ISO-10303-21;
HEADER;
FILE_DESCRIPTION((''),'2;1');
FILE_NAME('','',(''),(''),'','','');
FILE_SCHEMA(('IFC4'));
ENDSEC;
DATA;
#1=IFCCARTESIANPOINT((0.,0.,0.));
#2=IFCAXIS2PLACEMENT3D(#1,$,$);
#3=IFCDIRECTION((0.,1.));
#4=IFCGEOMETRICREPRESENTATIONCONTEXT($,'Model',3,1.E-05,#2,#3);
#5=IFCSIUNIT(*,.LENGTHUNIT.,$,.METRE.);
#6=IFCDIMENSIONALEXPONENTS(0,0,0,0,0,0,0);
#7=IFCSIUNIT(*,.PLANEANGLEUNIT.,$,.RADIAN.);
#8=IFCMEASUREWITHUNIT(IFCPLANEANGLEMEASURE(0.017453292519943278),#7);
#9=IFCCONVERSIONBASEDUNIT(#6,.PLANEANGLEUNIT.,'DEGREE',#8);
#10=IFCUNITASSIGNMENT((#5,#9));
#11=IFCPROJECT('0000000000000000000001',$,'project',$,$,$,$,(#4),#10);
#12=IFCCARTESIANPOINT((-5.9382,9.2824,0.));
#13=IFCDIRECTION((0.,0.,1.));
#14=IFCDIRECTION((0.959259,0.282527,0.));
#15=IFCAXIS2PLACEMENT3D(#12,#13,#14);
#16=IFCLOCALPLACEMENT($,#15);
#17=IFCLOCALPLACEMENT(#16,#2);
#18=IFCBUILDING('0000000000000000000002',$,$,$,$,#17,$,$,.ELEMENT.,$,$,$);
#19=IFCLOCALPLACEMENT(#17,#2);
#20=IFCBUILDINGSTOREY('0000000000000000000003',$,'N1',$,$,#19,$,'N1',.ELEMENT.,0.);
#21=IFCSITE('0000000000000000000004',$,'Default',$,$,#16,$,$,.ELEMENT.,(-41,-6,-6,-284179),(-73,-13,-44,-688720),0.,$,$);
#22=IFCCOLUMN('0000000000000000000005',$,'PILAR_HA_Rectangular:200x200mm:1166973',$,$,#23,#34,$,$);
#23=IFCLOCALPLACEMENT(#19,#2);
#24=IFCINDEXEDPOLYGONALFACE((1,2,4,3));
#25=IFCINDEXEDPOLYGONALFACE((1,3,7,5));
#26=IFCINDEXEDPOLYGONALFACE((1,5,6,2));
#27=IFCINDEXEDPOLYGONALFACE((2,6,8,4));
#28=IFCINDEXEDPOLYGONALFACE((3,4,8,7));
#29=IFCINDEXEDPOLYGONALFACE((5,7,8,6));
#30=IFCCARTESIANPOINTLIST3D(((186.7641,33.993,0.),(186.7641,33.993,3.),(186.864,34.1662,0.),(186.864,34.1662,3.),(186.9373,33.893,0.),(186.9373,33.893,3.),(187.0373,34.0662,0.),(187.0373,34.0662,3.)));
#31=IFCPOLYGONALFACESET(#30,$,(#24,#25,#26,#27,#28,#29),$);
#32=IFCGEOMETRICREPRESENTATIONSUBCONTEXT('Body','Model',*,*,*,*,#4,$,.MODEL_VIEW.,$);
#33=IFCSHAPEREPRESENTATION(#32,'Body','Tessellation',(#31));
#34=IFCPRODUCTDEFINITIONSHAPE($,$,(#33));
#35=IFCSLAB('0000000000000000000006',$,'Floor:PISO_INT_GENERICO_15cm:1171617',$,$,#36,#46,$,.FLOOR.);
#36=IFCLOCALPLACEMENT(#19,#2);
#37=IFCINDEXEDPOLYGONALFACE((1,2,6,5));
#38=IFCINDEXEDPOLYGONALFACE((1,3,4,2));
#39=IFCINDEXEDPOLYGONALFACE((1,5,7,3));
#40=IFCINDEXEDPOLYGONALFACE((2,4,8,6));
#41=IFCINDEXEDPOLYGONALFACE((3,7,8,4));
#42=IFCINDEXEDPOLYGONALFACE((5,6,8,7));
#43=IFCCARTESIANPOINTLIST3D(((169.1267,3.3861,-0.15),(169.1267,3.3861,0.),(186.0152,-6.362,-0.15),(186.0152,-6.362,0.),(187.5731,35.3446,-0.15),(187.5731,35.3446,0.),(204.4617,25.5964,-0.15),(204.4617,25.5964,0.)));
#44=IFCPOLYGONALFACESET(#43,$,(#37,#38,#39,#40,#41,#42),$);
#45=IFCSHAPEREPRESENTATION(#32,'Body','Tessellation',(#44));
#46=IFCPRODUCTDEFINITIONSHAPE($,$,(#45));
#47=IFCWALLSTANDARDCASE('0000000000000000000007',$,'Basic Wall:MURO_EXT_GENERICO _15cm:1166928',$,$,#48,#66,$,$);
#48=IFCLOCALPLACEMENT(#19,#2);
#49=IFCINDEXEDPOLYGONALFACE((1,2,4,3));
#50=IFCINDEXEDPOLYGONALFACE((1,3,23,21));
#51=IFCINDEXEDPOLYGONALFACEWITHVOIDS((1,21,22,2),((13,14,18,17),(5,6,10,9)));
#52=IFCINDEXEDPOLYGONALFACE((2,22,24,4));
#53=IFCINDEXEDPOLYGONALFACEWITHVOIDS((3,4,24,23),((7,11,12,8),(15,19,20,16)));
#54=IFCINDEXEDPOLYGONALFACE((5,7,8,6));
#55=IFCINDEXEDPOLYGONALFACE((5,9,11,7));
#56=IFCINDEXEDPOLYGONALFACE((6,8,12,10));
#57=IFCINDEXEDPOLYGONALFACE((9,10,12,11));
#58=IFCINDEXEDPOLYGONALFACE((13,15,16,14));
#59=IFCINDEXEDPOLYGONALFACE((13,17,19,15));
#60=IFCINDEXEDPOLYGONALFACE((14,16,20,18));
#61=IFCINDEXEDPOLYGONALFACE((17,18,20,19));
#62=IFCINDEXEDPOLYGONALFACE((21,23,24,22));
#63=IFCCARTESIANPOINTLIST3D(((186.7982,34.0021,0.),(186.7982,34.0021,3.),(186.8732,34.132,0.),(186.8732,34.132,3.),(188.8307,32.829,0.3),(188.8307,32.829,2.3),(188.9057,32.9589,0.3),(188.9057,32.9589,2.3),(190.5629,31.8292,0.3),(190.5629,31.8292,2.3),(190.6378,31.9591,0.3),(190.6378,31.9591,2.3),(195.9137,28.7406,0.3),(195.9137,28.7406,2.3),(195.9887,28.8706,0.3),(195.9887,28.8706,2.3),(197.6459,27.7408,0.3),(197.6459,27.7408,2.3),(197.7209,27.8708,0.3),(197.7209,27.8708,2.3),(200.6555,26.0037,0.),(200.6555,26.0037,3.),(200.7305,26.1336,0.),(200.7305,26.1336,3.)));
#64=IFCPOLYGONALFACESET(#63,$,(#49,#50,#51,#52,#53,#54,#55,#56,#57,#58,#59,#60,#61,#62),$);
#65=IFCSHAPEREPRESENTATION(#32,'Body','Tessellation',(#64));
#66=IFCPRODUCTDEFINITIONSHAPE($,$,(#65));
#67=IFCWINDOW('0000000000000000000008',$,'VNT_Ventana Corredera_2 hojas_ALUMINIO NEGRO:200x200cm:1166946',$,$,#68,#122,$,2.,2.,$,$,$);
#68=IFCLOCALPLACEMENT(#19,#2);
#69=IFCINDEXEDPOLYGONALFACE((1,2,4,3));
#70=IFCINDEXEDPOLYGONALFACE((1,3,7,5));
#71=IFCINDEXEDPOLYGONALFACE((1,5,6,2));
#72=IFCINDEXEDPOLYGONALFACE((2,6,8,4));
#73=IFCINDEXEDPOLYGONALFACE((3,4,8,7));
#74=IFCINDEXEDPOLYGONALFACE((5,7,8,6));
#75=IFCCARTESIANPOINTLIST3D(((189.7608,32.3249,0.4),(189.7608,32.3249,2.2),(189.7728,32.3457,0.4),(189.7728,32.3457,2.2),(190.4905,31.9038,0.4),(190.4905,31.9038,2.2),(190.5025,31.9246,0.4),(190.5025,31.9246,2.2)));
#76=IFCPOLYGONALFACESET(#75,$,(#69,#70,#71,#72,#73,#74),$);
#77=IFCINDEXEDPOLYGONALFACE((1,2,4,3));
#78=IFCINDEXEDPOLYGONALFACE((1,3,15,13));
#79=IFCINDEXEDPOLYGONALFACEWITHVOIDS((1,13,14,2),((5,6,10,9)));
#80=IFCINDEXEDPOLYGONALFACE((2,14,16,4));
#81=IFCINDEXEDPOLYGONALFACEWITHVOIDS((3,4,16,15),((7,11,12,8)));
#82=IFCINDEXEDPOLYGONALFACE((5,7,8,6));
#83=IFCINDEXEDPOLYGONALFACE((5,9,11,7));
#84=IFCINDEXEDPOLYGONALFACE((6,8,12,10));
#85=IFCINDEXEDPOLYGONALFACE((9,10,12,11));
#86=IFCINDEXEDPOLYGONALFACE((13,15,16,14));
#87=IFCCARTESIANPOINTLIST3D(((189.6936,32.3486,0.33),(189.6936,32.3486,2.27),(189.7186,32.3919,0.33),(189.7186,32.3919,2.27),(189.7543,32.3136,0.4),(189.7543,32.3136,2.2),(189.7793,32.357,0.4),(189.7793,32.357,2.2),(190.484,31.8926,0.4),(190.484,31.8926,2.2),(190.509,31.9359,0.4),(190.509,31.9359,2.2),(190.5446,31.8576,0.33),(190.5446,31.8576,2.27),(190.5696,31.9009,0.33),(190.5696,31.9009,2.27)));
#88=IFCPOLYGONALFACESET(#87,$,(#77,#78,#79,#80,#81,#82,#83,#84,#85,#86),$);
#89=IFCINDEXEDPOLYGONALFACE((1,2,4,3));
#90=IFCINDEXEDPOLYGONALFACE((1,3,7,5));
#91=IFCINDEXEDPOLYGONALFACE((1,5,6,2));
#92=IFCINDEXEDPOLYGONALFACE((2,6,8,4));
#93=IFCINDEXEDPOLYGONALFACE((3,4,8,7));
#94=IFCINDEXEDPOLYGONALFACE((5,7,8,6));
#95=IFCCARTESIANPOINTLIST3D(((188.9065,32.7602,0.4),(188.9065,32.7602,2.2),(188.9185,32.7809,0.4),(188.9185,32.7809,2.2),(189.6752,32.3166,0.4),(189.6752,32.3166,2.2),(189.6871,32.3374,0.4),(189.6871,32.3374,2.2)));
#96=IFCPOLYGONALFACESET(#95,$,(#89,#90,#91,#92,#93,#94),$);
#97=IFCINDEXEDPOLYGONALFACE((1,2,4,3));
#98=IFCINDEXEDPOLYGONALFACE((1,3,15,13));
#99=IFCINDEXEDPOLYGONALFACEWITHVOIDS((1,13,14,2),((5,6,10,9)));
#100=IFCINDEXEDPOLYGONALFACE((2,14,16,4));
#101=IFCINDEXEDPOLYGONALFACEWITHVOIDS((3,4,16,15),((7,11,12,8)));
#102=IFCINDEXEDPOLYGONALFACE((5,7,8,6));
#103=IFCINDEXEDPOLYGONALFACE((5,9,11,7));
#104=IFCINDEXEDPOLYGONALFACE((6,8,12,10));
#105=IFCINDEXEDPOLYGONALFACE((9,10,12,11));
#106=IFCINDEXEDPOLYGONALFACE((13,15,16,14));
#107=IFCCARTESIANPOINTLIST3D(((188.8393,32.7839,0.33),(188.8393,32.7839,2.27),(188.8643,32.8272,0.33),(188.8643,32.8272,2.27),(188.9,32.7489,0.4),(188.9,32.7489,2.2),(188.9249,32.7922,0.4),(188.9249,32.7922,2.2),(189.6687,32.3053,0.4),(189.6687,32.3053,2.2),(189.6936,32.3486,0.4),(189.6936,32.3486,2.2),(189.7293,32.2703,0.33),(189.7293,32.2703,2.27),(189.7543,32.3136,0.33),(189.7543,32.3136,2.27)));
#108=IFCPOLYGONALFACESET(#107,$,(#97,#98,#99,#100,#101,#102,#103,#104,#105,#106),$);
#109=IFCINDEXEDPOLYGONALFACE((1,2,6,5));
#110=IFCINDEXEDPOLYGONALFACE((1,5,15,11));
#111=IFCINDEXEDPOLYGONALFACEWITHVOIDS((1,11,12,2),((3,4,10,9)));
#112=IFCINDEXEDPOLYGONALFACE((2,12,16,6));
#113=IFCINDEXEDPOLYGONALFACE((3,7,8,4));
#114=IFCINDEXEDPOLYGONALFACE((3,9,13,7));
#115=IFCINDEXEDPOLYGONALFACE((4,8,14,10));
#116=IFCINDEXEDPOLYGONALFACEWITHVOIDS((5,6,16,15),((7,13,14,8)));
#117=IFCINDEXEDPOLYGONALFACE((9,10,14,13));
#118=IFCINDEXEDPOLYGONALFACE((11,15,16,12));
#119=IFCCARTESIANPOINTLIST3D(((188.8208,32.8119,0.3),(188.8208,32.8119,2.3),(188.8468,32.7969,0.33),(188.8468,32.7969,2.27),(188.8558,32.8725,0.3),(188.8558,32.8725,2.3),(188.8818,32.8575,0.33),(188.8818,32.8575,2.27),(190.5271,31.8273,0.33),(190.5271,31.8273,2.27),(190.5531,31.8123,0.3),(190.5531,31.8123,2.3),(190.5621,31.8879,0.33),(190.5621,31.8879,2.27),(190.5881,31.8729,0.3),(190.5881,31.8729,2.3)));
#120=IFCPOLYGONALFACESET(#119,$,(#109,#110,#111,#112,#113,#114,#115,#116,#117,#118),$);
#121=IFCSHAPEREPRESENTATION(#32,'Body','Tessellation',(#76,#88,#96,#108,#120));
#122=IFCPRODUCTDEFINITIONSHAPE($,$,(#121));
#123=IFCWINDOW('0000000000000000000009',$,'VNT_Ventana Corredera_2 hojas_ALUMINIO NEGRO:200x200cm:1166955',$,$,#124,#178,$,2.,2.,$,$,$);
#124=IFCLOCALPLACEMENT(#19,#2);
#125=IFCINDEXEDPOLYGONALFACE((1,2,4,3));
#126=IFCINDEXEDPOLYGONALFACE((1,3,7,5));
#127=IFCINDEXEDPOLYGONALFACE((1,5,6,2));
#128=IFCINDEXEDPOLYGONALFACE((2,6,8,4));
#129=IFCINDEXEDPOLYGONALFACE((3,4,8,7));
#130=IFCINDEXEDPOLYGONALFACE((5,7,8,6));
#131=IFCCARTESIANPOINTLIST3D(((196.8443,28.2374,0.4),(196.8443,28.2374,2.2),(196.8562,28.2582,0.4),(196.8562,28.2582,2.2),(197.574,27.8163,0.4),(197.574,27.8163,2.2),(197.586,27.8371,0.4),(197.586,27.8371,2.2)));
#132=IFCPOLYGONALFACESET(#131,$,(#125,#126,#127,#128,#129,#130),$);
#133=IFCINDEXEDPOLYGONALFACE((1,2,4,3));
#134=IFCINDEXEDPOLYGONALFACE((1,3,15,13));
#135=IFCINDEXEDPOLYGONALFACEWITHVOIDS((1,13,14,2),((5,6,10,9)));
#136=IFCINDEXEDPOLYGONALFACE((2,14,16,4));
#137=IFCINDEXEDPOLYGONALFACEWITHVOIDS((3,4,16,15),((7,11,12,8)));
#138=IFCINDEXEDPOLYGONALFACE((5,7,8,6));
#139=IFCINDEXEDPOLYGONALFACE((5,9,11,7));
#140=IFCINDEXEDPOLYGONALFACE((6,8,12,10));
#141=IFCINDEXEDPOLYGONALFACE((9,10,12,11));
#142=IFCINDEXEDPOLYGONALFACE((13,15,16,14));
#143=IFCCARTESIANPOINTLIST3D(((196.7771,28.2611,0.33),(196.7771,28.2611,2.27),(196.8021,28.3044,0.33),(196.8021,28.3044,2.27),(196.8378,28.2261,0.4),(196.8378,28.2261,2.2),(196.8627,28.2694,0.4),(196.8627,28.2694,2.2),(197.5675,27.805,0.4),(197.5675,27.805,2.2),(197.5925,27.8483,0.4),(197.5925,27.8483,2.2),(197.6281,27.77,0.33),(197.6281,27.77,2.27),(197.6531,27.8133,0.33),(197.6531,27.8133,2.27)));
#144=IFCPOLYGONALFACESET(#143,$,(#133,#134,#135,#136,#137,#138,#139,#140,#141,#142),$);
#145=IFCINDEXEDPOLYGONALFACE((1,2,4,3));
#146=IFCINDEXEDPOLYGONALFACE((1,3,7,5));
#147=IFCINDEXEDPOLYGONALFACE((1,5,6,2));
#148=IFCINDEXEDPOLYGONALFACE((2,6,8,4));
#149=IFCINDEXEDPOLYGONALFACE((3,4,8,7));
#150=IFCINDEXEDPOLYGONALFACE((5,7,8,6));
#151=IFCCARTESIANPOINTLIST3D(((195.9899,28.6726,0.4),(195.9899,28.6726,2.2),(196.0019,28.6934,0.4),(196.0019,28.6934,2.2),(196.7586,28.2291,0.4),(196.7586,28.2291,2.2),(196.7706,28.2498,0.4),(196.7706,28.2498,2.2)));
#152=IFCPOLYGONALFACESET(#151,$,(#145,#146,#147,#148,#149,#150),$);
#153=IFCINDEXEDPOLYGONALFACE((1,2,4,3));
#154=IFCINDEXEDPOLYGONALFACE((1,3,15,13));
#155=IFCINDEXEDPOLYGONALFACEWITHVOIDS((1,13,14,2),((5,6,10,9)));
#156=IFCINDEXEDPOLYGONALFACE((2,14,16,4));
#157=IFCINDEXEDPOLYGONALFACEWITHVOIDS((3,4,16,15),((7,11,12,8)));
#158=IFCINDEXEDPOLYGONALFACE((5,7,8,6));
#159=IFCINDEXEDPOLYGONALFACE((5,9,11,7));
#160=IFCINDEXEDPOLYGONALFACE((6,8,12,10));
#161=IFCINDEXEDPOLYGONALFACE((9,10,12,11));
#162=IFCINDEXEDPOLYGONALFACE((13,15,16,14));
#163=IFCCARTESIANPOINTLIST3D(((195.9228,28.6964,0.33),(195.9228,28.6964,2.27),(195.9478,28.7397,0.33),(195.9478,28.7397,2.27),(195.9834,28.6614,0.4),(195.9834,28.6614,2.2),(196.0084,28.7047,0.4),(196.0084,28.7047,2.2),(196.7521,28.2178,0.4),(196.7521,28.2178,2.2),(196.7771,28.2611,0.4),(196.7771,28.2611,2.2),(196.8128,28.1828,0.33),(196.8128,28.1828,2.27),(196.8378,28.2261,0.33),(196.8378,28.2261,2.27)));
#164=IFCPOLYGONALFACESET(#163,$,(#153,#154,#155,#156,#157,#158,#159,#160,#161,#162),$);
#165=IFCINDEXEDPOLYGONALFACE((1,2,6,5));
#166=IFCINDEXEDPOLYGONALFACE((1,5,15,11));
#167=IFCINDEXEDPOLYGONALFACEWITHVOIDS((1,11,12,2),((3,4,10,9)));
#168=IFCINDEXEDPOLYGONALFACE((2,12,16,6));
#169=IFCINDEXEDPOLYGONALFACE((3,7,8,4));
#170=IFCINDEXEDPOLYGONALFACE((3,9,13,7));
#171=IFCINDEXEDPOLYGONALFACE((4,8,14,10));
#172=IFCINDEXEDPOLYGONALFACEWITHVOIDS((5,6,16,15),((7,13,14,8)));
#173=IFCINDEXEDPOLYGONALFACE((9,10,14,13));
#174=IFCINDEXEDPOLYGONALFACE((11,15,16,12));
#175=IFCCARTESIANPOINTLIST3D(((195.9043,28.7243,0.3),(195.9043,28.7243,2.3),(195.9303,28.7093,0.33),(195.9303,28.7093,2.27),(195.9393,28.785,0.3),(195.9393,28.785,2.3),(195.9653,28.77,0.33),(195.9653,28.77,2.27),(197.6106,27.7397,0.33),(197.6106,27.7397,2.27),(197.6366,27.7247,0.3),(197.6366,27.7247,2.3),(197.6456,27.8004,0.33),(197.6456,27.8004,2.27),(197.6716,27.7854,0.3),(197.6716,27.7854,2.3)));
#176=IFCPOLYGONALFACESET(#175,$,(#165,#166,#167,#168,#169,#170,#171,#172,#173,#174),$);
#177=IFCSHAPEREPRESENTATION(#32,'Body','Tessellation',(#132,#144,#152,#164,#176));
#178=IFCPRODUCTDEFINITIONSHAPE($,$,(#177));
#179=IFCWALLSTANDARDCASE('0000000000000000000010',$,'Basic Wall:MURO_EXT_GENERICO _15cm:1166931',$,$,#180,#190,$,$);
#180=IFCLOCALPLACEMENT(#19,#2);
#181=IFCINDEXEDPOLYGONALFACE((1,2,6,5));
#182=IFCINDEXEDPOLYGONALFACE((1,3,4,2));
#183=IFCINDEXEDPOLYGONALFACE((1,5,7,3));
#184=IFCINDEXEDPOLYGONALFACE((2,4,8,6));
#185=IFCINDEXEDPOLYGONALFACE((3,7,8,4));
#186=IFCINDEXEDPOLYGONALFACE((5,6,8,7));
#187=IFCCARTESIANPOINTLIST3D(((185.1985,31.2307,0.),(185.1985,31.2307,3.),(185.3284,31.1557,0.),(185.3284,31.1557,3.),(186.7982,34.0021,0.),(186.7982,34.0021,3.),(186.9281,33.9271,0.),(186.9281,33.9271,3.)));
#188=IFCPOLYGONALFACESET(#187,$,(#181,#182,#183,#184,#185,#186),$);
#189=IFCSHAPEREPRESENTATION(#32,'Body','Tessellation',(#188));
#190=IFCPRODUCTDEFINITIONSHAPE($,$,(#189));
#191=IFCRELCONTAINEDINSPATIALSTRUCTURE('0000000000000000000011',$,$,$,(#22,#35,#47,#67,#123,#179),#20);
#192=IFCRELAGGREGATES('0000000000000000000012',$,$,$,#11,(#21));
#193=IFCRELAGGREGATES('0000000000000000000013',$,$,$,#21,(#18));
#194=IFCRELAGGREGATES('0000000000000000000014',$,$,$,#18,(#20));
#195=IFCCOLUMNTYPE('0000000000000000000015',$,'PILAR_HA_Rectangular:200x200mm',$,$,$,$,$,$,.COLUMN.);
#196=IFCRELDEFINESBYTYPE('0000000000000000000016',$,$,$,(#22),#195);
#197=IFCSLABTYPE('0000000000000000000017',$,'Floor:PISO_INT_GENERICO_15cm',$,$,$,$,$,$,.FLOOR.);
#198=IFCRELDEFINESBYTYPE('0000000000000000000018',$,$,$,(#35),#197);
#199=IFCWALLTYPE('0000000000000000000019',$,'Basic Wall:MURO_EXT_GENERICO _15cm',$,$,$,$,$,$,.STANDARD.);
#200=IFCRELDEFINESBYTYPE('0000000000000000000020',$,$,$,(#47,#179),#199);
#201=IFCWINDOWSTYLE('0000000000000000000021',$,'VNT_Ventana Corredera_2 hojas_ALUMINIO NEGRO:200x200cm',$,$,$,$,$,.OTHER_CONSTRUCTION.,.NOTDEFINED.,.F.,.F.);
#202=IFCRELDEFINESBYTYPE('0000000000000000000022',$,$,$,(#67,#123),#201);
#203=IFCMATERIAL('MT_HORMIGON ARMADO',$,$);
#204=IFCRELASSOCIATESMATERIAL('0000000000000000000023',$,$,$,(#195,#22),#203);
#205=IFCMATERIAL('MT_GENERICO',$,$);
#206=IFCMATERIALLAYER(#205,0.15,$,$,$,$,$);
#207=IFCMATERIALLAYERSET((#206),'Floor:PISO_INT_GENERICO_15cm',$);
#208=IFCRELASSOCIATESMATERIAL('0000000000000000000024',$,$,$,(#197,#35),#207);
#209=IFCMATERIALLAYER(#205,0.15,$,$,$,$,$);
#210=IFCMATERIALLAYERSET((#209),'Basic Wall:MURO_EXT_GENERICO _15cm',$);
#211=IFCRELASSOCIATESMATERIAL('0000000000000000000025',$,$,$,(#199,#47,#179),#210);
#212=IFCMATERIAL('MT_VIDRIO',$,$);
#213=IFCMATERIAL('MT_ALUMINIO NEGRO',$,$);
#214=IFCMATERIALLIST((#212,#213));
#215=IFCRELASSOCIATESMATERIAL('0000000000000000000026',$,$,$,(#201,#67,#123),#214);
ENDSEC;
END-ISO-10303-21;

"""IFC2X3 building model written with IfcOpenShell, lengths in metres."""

from ifc_helpers import new_model, entity, si_unit, converted_unit, direction, frame, frame_2d, origin, origin_2d_with_axis, place, context, subcontext, project, spatial, polyline, rectangle, outline, extrude, source, transform, mapped, material, material_list, layer, layer_set, layer_usage, type_object, type_shapes, element, fill, save


model = new_model("IFC2X3")

# Units and contexts
model_context = context("Model", 3, precision=1e-05, world=origin(), true_north=direction((0.0, 1.0)))
body_context = subcontext(model_context, "Body", "Model", "MODEL_VIEW")
ifc_project = project(units=[si_unit("LENGTHUNIT", "METRE"), converted_unit("PLANEANGLEUNIT", "DEGREE", entity("IfcPlaneAngleMeasure", 0.017453292519943278), si_unit("PLANEANGLEUNIT", "RADIAN"), dimensions=[0, 0, 0, 0, 0, 0, 0])], contexts=[model_context])

# Site, building, storey
site_placement = place(None, frame((-5.9382, 9.2824, 0.0), z_axis=(0.0, 0.0, 1.0), x_axis=(0.959259, 0.282527, 0.0)))
site = spatial("IfcSite", under=ifc_project, at=site_placement, Name="Default", CompositionType="ELEMENT", RefLatitude=(-41, -6, -6, -284179), RefLongitude=(-73, -13, -44, -688720), RefElevation=0.0)
building_placement = place(site_placement, origin())
building = spatial("IfcBuilding", under=site, at=building_placement, CompositionType="ELEMENT")
storey_placement = place(building_placement, origin())
storey = spatial("IfcBuildingStorey", under=building, at=storey_placement, Name="N1", LongName="N1", CompositionType="ELEMENT", Elevation=0.0)

# Column
ifc_material_1 = material(Name="MT_HORMIGON ARMADO")
column_type = type_object("IfcColumnType", Name="PILAR_HA_Rectangular:200x200mm", PredefinedType="COLUMN", material=ifc_material_1)
shared_shape_1 = source(origin(), body_context, "Body", "SweptSolid", [
    extrude(rectangle(XDim=0.2, YDim=0.2, at=origin_2d_with_axis()), frame((0.0, 0.0, 0.0), z_axis=(0.0, 0.0, 1.0), x_axis=(-1.0, 0.0, 0.0)), (0.0, 0.0, 1.0), 3.0),
])
type_shapes(column_type, [shared_shape_1])
column_placement = place(storey_placement, frame((186.9007, 34.0296, 0.0), z_axis=(0.0, 0.0, 1.0), x_axis=(0.866082, -0.499903, 0.0)))
element("IfcColumn", 1, at=column_placement, inside=storey, type_object=column_type, material=ifc_material_1, Name="PILAR_HA_Rectangular:200x200mm:1166973", context=body_context, shape_type="MappedRepresentation", body=[
    mapped(shared_shape_1, transform((0.0, 0.0, 0.0), scale=1.0)),
])

# Slab
ifc_material_2 = material(Name="MT_GENERICO")
ifc_layer_1 = layer(ifc_material_2, 0.15)
ifc_layer_set_1 = layer_set([ifc_layer_1], Name="Floor:PISO_INT_GENERICO_15cm")
ifc_layer_usage_1 = layer_usage(ifc_layer_set_1, "AXIS3", "POSITIVE", 0.0)
slab_type = type_object("IfcSlabType", Name="Floor:PISO_INT_GENERICO_15cm", PredefinedType="FLOOR", material=ifc_layer_set_1)
slab_placement = place(storey_placement, origin())
element("IfcSlab", 2, at=slab_placement, inside=storey, type_object=slab_type, material=ifc_layer_usage_1, Name="Floor:PISO_INT_GENERICO_15cm:1171617", PredefinedType="FLOOR", context=body_context, shape_type="SweptSolid", body=[
    extrude(rectangle(XDim=36.9, YDim=19.5, at=frame_2d((0.0, 0.0), x_axis=(1.0, 0.0))), frame((186.7942, 14.4913, 0.0), z_axis=(0.0, 0.0, -1.0), x_axis=(-0.499903, -0.866082, 0.0)), (0.0, 0.0, 1.0), 0.15),
])

# Wall, openings, windows
ifc_layer_2 = layer(ifc_material_2, 0.15)
ifc_layer_set_2 = layer_set([ifc_layer_2], Name="Basic Wall:MURO_EXT_GENERICO _15cm")
ifc_layer_usage_2 = layer_usage(ifc_layer_set_2, "AXIS2", "NEGATIVE", 0.075)
wall_type_1 = type_object("IfcWallType", Name="Basic Wall:MURO_EXT_GENERICO _15cm", PredefinedType="STANDARD", material=ifc_layer_set_2)
wall_1_placement = place(storey_placement, frame((186.8357, 34.0671, 0.0), z_axis=(0.0, 0.0, 1.0), x_axis=(0.866082, -0.499903, 0.0)))
wall_1 = element("IfcWallStandardCase", 3, at=wall_1_placement, inside=storey, type_object=wall_type_1, material=ifc_layer_usage_2, Name="Basic Wall:MURO_EXT_GENERICO _15cm:1166928", context=body_context, shape_type="SweptSolid", body=[
    extrude(rectangle(XDim=16.0, YDim=0.15, at=frame_2d((8.0, 0.0), x_axis=(-1.0, 0.0))), origin(), (0.0, 0.0, 1.0), 3.0),
])
opening_1_placement = place(wall_1_placement, frame((4.3468, 0.075, 0.3)))
opening_1 = element("IfcOpeningElement", 4, at=opening_1_placement, cuts=wall_1, ObjectType="Opening", context=body_context, shape_type="SweptSolid", body=[
    extrude(rectangle(XDim=2.0, YDim=2.0, at=frame_2d((1.0, 1.0), x_axis=(1.0, 0.0))), frame((0.0, 0.0, 0.0), z_axis=(0.0, -1.0, 0.0), x_axis=(0.0, 0.0, 1.0)), (0.0, 0.0, 1.0), 0.15),
])
opening_2_placement = place(wall_1_placement, frame((12.525, 0.075, 0.3)))
opening_2 = element("IfcOpeningElement", 5, at=opening_2_placement, cuts=wall_1, ObjectType="Opening", context=body_context, shape_type="SweptSolid", body=[
    extrude(rectangle(XDim=2.0, YDim=2.0, at=frame_2d((1.0, 1.0), x_axis=(1.0, 0.0))), frame((0.0, 0.0, 0.0), z_axis=(0.0, -1.0, 0.0), x_axis=(0.0, 0.0, 1.0)), (0.0, 0.0, 1.0), 0.15),
])
ifc_material_3 = material(Name="MT_VIDRIO")
ifc_material_4 = material(Name="MT_ALUMINIO NEGRO")
ifc_material_list_1 = material_list([ifc_material_3, ifc_material_4])
window_style = type_object("IfcWindowStyle", Name="VNT_Ventana Corredera_2 hojas_ALUMINIO NEGRO:200x200cm", ConstructionType="OTHER_CONSTRUCTION", OperationType="NOTDEFINED", ParameterTakesPrecedence=False, Sizeable=False, material=ifc_material_list_1)
shared_shape_2 = source(origin(), body_context, "Body", "SweptSolid", [
    extrude(rectangle(XDim=0.024, YDim=0.8425, at=frame_2d((0.0, 0.0), x_axis=(1.0, 0.0))), frame((0.5213, 0.11, 0.1), z_axis=(0.0, 0.0, 1.0), x_axis=(0.0, -1.0, 0.0)), (0.0, 0.0, 1.0), 1.8),
    extrude(outline(polyline([(-0.4912, -0.97), (0.4913, -0.97), (0.4912, 0.97), (-0.4912, 0.97), (-0.4912, -0.97)]), holes=[polyline([(0.4213, -0.9), (-0.4212, -0.9), (-0.4213, 0.9), (0.4213, 0.9), (0.4213, -0.9)])]), frame((0.5213, 0.135, 1.0), z_axis=(0.0, -1.0, 0.0), x_axis=(1.0, 0.0, 0.0)), (0.0, 0.0, 1.0), 0.05),
    extrude(rectangle(XDim=0.024, YDim=0.8875, at=frame_2d((0.0, 0.0), x_axis=(1.0, 0.0))), frame((1.4563, 0.16, 0.1), z_axis=(0.0, 0.0, 1.0), x_axis=(0.0, -1.0, 0.0)), (0.0, 0.0, 1.0), 1.8),
    extrude(outline(polyline([(-0.5138, -0.97), (0.5138, -0.97), (0.5138, 0.97), (-0.5138, 0.97), (-0.5138, -0.97)]), holes=[polyline([(0.4438, -0.9), (-0.4438, -0.9), (-0.4438, 0.9), (0.4438, 0.9), (0.4438, -0.9)])]), frame((1.4563, 0.185, 1.0), z_axis=(0.0, -1.0, 0.0), x_axis=(1.0, 0.0, 0.0)), (0.0, 0.0, 1.0), 0.05),
    extrude(outline(polyline([(-1.0, -1.0), (1.0, -1.0), (1.0, 1.0), (-1.0, 1.0), (-1.0, -1.0)]), holes=[polyline([(0.97, -0.97), (-0.97, -0.97), (-0.97, 0.97), (0.97, 0.97), (0.97, -0.97)])]), frame((1.0, 0.17, 1.0), z_axis=(0.0, -1.0, 0.0), x_axis=(0.0, 0.0, -1.0)), (0.0, 0.0, 1.0), 0.07),
])
type_shapes(window_style, [shared_shape_2])
window_1_placement = place(opening_1_placement, frame((0.0, 0.0005, 0.0), z_axis=(0.0, 0.0, 1.0), x_axis=(-1.0, -0.000112, 0.0)))
window_1 = element("IfcWindow", 6, at=window_1_placement, inside=storey, type_object=window_style, material=ifc_material_list_1, Name="VNT_Ventana Corredera_2 hojas_ALUMINIO NEGRO:200x200cm:1166946", OverallHeight=2.0, OverallWidth=2.0, context=body_context, shape_type="MappedRepresentation", body=[
    mapped(shared_shape_2, transform((0.0, 0.0, 0.0), scale=1.0)),
])
fill(opening_1, window_1)
window_2_placement = place(opening_2_placement, frame((0.0, 0.0014, 0.0), z_axis=(0.0, 0.0, 1.0), x_axis=(-1.0, -0.000112, 0.0)))
window_2 = element("IfcWindow", 7, at=window_2_placement, inside=storey, type_object=window_style, material=ifc_material_list_1, Name="VNT_Ventana Corredera_2 hojas_ALUMINIO NEGRO:200x200cm:1166955", OverallHeight=2.0, OverallWidth=2.0, context=body_context, shape_type="MappedRepresentation", body=[
    mapped(shared_shape_2, transform((0.0, 0.0, 0.0), scale=1.0)),
])
fill(opening_2, window_2)

# Wall
ifc_layer_usage_3 = layer_usage(ifc_layer_set_2, "AXIS2", "NEGATIVE", 0.075)
wall_2_placement = place(storey_placement, frame((185.2635, 31.1932, 0.0), z_axis=(0.0, 0.0, 1.0), x_axis=(0.499903, 0.866082, 0.0)))
element("IfcWallStandardCase", 8, at=wall_2_placement, inside=storey, type_object=wall_type_1, material=ifc_layer_usage_3, Name="Basic Wall:MURO_EXT_GENERICO _15cm:1166931", context=body_context, shape_type="SweptSolid", body=[
    extrude(rectangle(XDim=3.2, YDim=0.15, at=frame_2d((1.6, 0.0), x_axis=(-1.0, 0.0))), origin(), (0.0, 0.0, 1.0), 3.0),
])

save(model, "model.ifc")
